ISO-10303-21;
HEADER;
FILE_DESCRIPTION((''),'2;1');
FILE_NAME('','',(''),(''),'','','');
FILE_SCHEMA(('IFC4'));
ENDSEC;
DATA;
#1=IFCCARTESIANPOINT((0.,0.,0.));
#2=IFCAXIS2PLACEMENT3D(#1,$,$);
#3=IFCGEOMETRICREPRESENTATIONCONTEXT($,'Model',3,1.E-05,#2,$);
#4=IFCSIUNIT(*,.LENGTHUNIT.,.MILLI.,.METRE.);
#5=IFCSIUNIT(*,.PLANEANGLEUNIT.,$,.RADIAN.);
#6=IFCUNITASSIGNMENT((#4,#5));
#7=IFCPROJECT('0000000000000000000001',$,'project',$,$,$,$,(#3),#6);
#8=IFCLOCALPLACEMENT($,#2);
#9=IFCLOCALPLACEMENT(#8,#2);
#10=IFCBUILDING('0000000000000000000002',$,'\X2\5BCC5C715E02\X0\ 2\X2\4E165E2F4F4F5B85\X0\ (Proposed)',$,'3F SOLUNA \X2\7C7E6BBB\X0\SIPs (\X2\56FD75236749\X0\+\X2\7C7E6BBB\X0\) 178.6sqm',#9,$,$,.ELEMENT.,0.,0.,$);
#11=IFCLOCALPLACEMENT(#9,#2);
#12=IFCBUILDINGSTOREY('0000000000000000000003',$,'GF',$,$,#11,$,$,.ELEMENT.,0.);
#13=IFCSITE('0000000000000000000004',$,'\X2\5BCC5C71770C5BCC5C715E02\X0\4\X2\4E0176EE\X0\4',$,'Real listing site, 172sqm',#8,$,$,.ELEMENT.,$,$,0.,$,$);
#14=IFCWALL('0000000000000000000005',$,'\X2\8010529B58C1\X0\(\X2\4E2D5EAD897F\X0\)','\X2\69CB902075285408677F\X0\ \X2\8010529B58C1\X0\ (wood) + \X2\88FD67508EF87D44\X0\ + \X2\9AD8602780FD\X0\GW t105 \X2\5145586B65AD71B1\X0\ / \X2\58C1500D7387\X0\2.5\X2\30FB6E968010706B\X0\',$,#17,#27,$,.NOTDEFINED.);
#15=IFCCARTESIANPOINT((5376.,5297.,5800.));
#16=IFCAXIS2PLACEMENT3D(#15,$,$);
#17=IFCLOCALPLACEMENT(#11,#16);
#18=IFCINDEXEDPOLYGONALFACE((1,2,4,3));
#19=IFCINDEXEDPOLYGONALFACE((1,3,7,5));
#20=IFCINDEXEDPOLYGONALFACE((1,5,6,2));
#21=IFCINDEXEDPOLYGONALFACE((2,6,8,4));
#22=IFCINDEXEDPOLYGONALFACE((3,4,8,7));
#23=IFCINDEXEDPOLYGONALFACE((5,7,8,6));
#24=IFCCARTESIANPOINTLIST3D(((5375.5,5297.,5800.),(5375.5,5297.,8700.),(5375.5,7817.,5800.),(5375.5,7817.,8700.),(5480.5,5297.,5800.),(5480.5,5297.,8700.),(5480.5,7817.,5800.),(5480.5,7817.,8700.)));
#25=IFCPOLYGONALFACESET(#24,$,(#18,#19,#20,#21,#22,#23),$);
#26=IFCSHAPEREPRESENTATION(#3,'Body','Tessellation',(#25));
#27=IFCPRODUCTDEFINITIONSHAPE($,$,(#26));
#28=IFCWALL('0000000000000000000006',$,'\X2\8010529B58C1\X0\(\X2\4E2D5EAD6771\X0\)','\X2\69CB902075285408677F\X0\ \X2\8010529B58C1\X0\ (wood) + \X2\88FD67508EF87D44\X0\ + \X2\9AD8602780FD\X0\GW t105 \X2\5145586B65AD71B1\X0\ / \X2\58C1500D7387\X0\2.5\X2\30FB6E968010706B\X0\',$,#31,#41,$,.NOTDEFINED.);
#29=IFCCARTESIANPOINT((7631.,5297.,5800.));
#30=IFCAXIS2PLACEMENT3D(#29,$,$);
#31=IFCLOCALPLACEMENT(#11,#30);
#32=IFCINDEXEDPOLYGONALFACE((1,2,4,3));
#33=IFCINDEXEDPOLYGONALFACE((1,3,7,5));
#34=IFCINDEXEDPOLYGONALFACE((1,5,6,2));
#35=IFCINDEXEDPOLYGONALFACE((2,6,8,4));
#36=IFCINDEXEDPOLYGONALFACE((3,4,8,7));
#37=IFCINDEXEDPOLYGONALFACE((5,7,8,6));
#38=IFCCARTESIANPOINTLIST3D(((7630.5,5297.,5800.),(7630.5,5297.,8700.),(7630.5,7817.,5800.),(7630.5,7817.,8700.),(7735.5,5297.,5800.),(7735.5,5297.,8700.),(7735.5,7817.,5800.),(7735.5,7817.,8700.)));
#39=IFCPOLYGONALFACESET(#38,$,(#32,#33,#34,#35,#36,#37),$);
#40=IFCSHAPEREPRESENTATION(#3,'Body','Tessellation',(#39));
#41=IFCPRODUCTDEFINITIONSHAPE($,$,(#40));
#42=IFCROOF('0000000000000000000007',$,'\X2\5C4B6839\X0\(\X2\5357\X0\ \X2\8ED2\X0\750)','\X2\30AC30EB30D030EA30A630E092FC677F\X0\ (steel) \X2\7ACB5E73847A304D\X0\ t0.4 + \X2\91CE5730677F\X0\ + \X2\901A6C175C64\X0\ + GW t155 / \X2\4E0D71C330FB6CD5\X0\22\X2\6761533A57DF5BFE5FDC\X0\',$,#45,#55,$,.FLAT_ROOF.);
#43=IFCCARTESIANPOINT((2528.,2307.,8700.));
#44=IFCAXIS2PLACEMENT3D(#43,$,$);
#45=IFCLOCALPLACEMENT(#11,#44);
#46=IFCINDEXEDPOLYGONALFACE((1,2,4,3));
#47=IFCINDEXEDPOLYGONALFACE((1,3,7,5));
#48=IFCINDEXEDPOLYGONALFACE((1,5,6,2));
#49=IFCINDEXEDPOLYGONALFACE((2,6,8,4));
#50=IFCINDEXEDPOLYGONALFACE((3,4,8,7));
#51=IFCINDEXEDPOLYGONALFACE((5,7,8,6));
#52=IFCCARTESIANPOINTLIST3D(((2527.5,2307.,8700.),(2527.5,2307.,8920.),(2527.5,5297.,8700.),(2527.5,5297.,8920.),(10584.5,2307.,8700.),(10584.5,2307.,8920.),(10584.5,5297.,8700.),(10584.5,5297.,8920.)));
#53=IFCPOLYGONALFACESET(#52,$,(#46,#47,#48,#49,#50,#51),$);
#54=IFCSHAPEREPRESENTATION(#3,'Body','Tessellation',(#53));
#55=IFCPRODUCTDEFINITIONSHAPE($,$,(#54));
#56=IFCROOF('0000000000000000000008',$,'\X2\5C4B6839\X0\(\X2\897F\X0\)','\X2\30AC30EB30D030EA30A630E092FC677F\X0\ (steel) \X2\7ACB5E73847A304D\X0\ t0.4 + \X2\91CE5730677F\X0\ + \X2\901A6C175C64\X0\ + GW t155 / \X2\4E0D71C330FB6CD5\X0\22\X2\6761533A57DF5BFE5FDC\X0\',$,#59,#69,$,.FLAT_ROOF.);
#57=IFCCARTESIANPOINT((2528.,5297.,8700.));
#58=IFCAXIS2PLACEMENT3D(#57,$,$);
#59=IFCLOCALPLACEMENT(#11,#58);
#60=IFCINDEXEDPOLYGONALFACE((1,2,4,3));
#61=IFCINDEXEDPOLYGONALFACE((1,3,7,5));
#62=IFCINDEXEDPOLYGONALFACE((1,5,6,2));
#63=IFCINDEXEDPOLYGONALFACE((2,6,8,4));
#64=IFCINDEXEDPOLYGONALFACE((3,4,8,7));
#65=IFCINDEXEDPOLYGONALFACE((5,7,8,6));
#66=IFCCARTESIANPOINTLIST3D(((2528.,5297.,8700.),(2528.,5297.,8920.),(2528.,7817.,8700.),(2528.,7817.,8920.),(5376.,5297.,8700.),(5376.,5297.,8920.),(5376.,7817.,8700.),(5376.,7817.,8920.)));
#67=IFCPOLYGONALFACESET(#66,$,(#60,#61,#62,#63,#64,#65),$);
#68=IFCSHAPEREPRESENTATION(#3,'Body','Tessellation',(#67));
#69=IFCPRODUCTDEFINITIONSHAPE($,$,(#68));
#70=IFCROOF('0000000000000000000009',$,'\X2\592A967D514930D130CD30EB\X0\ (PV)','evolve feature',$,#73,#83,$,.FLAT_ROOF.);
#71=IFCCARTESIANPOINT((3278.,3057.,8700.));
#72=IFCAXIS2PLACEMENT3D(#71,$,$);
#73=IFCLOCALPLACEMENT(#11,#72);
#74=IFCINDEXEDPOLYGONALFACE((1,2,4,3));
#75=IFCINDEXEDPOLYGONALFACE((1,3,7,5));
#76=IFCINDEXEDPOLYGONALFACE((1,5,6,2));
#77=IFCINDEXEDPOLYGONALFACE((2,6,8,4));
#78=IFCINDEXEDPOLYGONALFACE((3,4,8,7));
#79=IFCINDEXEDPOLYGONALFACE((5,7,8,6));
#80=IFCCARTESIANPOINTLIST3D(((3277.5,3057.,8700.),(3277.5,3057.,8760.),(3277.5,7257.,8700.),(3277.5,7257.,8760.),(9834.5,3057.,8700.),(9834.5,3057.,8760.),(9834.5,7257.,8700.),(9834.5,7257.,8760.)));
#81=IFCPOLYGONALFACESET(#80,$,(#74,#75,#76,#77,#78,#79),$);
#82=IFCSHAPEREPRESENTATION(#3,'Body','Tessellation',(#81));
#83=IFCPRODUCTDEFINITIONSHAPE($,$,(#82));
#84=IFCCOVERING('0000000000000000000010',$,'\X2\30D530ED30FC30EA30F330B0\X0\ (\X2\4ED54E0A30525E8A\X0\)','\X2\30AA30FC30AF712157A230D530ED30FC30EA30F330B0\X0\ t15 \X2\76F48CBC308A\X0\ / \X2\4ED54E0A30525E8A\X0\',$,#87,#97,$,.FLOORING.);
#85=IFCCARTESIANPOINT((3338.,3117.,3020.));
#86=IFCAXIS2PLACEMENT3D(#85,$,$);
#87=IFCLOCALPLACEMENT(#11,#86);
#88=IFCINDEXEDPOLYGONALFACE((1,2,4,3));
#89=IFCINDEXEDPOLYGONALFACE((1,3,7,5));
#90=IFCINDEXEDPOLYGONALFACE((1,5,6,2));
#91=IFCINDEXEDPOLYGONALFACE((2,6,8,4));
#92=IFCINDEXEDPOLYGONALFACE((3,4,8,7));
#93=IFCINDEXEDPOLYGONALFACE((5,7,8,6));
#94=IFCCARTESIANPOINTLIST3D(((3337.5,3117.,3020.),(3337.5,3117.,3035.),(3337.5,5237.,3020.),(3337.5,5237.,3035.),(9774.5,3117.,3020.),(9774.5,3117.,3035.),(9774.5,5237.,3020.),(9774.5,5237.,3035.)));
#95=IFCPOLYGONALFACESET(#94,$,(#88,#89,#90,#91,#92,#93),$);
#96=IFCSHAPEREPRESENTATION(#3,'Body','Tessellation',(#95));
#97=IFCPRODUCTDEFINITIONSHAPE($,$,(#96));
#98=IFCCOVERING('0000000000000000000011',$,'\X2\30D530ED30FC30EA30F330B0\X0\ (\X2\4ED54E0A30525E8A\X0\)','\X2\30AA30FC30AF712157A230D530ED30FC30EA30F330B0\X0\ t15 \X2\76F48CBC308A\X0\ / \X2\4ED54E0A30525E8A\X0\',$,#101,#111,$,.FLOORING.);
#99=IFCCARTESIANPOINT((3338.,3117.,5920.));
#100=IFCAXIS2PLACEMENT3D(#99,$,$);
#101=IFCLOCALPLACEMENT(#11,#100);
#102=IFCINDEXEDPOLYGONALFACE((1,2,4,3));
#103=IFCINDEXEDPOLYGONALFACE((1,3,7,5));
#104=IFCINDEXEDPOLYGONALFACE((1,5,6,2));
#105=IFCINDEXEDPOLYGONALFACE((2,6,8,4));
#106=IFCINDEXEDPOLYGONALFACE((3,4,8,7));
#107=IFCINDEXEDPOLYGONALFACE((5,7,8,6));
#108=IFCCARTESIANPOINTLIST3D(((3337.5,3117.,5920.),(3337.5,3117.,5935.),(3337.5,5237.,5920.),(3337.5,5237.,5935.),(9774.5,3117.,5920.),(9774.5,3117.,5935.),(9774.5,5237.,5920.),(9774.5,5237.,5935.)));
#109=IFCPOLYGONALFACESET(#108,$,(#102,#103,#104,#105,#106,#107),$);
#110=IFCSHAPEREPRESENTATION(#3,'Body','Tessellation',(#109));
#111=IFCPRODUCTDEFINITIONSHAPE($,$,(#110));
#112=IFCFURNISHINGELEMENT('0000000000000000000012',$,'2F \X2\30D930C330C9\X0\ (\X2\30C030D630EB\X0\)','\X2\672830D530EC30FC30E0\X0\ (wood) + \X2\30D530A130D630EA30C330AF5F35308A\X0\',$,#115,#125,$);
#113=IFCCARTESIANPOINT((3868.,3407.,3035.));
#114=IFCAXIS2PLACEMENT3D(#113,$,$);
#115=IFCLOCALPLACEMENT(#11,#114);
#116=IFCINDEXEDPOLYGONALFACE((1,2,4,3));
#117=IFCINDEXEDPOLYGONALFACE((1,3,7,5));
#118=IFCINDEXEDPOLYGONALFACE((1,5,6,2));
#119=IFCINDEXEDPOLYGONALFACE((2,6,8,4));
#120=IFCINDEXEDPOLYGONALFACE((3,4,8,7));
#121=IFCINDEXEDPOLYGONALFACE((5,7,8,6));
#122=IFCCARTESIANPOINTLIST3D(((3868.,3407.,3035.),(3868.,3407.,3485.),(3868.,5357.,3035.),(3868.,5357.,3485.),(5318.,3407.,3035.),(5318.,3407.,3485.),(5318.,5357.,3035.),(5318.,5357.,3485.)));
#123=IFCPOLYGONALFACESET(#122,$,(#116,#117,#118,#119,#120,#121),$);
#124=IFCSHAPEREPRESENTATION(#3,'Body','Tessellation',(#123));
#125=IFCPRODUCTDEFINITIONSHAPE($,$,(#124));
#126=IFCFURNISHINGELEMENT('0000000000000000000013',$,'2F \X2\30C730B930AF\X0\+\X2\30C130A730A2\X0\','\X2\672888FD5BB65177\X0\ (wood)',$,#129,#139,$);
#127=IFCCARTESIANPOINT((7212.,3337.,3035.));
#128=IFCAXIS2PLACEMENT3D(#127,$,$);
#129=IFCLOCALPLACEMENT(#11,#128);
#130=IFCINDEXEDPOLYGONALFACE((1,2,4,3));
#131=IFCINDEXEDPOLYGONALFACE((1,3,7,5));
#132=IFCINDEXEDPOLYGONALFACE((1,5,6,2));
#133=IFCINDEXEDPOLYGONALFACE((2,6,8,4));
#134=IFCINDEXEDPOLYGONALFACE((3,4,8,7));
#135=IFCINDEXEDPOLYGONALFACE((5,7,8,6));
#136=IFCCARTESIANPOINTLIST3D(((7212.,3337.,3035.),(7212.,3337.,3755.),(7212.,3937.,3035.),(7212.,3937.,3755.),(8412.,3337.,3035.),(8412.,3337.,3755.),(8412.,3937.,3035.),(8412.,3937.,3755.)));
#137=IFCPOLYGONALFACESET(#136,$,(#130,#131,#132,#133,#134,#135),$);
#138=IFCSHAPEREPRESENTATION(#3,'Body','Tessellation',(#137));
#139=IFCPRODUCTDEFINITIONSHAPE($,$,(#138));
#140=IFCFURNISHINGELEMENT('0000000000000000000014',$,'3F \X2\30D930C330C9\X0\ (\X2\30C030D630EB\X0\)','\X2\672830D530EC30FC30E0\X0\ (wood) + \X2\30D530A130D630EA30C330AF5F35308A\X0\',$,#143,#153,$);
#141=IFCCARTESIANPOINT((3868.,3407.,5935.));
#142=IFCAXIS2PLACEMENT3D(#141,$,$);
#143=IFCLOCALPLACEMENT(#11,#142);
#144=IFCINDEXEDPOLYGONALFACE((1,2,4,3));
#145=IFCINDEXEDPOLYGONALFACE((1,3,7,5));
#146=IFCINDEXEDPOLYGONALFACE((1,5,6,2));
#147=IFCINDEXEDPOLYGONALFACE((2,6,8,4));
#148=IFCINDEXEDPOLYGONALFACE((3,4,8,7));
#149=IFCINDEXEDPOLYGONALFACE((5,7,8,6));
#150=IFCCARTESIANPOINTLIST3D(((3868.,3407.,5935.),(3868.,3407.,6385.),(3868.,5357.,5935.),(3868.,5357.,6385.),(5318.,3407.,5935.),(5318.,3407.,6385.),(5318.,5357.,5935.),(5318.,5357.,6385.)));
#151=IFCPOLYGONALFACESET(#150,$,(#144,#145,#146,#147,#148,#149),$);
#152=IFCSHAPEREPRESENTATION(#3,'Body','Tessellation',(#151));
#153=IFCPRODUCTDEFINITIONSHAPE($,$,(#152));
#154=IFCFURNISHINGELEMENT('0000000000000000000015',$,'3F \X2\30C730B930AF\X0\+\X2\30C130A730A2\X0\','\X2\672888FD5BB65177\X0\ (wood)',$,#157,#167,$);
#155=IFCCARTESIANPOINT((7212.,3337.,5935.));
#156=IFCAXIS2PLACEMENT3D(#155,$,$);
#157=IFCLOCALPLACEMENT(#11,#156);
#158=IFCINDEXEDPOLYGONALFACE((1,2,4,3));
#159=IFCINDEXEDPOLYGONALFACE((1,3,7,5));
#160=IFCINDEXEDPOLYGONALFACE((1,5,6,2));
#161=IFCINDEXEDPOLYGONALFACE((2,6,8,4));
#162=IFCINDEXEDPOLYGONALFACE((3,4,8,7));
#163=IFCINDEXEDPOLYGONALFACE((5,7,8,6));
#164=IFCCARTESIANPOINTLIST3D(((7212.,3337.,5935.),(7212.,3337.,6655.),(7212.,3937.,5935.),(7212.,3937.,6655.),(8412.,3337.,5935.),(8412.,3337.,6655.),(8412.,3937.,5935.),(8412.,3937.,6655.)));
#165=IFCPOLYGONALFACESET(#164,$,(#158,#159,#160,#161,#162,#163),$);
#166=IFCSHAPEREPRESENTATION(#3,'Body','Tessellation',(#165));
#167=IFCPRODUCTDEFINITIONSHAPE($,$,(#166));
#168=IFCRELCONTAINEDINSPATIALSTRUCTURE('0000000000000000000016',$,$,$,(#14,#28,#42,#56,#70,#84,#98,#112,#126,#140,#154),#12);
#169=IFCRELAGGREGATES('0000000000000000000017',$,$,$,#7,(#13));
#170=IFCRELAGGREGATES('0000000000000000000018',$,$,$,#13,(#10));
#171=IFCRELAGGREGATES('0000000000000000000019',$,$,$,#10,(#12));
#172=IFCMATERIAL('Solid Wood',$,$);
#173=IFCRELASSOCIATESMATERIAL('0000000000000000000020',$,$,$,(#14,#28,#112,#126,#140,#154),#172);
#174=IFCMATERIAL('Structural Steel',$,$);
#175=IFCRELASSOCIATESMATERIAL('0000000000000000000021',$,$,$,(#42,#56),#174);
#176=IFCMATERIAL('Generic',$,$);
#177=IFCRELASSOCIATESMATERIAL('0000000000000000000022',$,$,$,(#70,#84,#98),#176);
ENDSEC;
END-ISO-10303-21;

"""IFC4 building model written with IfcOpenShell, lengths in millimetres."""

from ifc_helpers import new_model, si_unit, frame, frame_2d, origin, place, context, project, spatial, rectangle, extrude, material, element, save


model = new_model("IFC4")

# Units and contexts
model_context = context("Model", 3, precision=1e-05, world=origin())
ifc_project = project(units=[si_unit("LENGTHUNIT", "METRE", prefix="MILLI"), si_unit("PLANEANGLEUNIT", "RADIAN")], contexts=[model_context])

# Site, building, storey
site_placement = place(None, origin())
site = spatial("IfcSite", under=ifc_project, at=site_placement, Name="富山県富山市4丁目4", ObjectType="Real listing site, 172sqm", CompositionType="ELEMENT", RefElevation=0.0)
building_placement = place(site_placement, origin())
building = spatial("IfcBuilding", under=site, at=building_placement, Name="富山市 2世帯住宅 (Proposed)", ObjectType="3F SOLUNA 籾殻SIPs (国産杉+籾殻) 178.6sqm", CompositionType="ELEMENT", ElevationOfRefHeight=0.0, ElevationOfTerrain=0.0)
storey_placement = place(building_placement, origin())
storey = spatial("IfcBuildingStorey", under=building, at=storey_placement, Name="GF", CompositionType="ELEMENT", Elevation=0.0)

# Shared definitions
ifc_material_1 = material(Name="Solid Wood")

# Walls
wall_1_placement = place(storey_placement, frame((5376.0, 5297.0, 5800.0)))
element("IfcWall", 1, at=wall_1_placement, inside=storey, material=ifc_material_1, Name="耐力壁(中庭西)", Description="構造用合板 耐力壁 (wood) + 製材軸組 + 高性能GW t105 充填断熱 / 壁倍率2.5・準耐火", PredefinedType="NOTDEFINED", context=model_context, shape_type="SweptSolid", body=[
    extrude(rectangle(XDim=105.0, YDim=2520.0, at=frame_2d((52.0, 1260.0))), frame((5376.0, 5297.0, 5800.0)), (0.0, 0.0, 1.0), 2900.0),
])
wall_2_placement = place(storey_placement, frame((7631.0, 5297.0, 5800.0)))
element("IfcWall", 2, at=wall_2_placement, inside=storey, material=ifc_material_1, Name="耐力壁(中庭東)", Description="構造用合板 耐力壁 (wood) + 製材軸組 + 高性能GW t105 充填断熱 / 壁倍率2.5・準耐火", PredefinedType="NOTDEFINED", context=model_context, shape_type="SweptSolid", body=[
    extrude(rectangle(XDim=105.0, YDim=2520.0, at=frame_2d((52.0, 1260.0))), frame((7631.0, 5297.0, 5800.0)), (0.0, 0.0, 1.0), 2900.0),
])

# Roofs
ifc_material_2 = material(Name="Structural Steel")
roof_1_placement = place(storey_placement, frame((2528.0, 2307.0, 8700.0)))
element("IfcRoof", 3, at=roof_1_placement, inside=storey, material=ifc_material_2, Name="屋根(南 軒750)", Description="ガルバリウム鋼板 (steel) 立平葺き t0.4 + 野地板 + 通気層 + GW t155 / 不燃・法22条区域対応", PredefinedType="FLAT_ROOF", context=model_context, shape_type="SweptSolid", body=[
    extrude(rectangle(XDim=8057.0, YDim=2990.0, at=frame_2d((4028.0, 1495.0))), frame((2528.0, 2307.0, 8700.0)), (0.0, 0.0, 1.0), 220.0),
])
roof_2_placement = place(storey_placement, frame((2528.0, 5297.0, 8700.0)))
element("IfcRoof", 4, at=roof_2_placement, inside=storey, material=ifc_material_2, Name="屋根(西)", Description="ガルバリウム鋼板 (steel) 立平葺き t0.4 + 野地板 + 通気層 + GW t155 / 不燃・法22条区域対応", PredefinedType="FLAT_ROOF", context=model_context, shape_type="SweptSolid", body=[
    extrude(rectangle(XDim=2848.0, YDim=2520.0, at=frame_2d((1424.0, 1260.0))), frame((2528.0, 5297.0, 8700.0)), (0.0, 0.0, 1.0), 220.0),
])
ifc_material_3 = material(Name="Generic")
roof_3_placement = place(storey_placement, frame((3278.0, 3057.0, 8700.0)))
element("IfcRoof", 5, at=roof_3_placement, inside=storey, material=ifc_material_3, Name="太陽光パネル (PV)", Description="evolve feature", PredefinedType="FLAT_ROOF", context=model_context, shape_type="SweptSolid", body=[
    extrude(rectangle(XDim=6557.0, YDim=4200.0, at=frame_2d((3278.0, 2100.0))), frame((3278.0, 3057.0, 8700.0)), (0.0, 0.0, 1.0), 60.0),
])

# Coverings
covering_1_placement = place(storey_placement, frame((3338.0, 3117.0, 3020.0)))
element("IfcCovering", 6, at=covering_1_placement, inside=storey, material=ifc_material_3, Name="フローリング (仕上げ床)", Description="オーク無垢フローリング t15 直貼り / 仕上げ床", PredefinedType="FLOORING", context=model_context, shape_type="SweptSolid", body=[
    extrude(rectangle(XDim=6437.0, YDim=2120.0, at=frame_2d((3218.0, 1060.0))), frame((3338.0, 3117.0, 3020.0)), (0.0, 0.0, 1.0), 15.0),
])
covering_2_placement = place(storey_placement, frame((3338.0, 3117.0, 5920.0)))
element("IfcCovering", 7, at=covering_2_placement, inside=storey, material=ifc_material_3, Name="フローリング (仕上げ床)", Description="オーク無垢フローリング t15 直貼り / 仕上げ床", PredefinedType="FLOORING", context=model_context, shape_type="SweptSolid", body=[
    extrude(rectangle(XDim=6437.0, YDim=2120.0, at=frame_2d((3218.0, 1060.0))), frame((3338.0, 3117.0, 5920.0)), (0.0, 0.0, 1.0), 15.0),
])

# Furnishing elements
furnishing_1_placement = place(storey_placement, frame((3868.0, 3407.0, 3035.0)))
element("IfcFurnishingElement", 8, at=furnishing_1_placement, inside=storey, material=ifc_material_1, Name="2F ベッド (ダブル)", Description="木フレーム (wood) + ファブリック張り", context=model_context, shape_type="SweptSolid", body=[
    extrude(rectangle(XDim=1450.0, YDim=1950.0, at=frame_2d((725.0, 975.0))), frame((3868.0, 3407.0, 3035.0)), (0.0, 0.0, 1.0), 450.0),
])
furnishing_2_placement = place(storey_placement, frame((7212.0, 3337.0, 3035.0)))
element("IfcFurnishingElement", 9, at=furnishing_2_placement, inside=storey, material=ifc_material_1, Name="2F デスク+チェア", Description="木製家具 (wood)", context=model_context, shape_type="SweptSolid", body=[
    extrude(rectangle(XDim=1200.0, YDim=600.0, at=frame_2d((600.0, 300.0))), frame((7212.0, 3337.0, 3035.0)), (0.0, 0.0, 1.0), 720.0),
])
furnishing_3_placement = place(storey_placement, frame((3868.0, 3407.0, 5935.0)))
element("IfcFurnishingElement", 10, at=furnishing_3_placement, inside=storey, material=ifc_material_1, Name="3F ベッド (ダブル)", Description="木フレーム (wood) + ファブリック張り", context=model_context, shape_type="SweptSolid", body=[
    extrude(rectangle(XDim=1450.0, YDim=1950.0, at=frame_2d((725.0, 975.0))), frame((3868.0, 3407.0, 5935.0)), (0.0, 0.0, 1.0), 450.0),
])
furnishing_4_placement = place(storey_placement, frame((7212.0, 3337.0, 5935.0)))
element("IfcFurnishingElement", 11, at=furnishing_4_placement, inside=storey, material=ifc_material_1, Name="3F デスク+チェア", Description="木製家具 (wood)", context=model_context, shape_type="SweptSolid", body=[
    extrude(rectangle(XDim=1200.0, YDim=600.0, at=frame_2d((600.0, 300.0))), frame((7212.0, 3337.0, 5935.0)), (0.0, 0.0, 1.0), 720.0),
])

save(model, "model.ifc")
